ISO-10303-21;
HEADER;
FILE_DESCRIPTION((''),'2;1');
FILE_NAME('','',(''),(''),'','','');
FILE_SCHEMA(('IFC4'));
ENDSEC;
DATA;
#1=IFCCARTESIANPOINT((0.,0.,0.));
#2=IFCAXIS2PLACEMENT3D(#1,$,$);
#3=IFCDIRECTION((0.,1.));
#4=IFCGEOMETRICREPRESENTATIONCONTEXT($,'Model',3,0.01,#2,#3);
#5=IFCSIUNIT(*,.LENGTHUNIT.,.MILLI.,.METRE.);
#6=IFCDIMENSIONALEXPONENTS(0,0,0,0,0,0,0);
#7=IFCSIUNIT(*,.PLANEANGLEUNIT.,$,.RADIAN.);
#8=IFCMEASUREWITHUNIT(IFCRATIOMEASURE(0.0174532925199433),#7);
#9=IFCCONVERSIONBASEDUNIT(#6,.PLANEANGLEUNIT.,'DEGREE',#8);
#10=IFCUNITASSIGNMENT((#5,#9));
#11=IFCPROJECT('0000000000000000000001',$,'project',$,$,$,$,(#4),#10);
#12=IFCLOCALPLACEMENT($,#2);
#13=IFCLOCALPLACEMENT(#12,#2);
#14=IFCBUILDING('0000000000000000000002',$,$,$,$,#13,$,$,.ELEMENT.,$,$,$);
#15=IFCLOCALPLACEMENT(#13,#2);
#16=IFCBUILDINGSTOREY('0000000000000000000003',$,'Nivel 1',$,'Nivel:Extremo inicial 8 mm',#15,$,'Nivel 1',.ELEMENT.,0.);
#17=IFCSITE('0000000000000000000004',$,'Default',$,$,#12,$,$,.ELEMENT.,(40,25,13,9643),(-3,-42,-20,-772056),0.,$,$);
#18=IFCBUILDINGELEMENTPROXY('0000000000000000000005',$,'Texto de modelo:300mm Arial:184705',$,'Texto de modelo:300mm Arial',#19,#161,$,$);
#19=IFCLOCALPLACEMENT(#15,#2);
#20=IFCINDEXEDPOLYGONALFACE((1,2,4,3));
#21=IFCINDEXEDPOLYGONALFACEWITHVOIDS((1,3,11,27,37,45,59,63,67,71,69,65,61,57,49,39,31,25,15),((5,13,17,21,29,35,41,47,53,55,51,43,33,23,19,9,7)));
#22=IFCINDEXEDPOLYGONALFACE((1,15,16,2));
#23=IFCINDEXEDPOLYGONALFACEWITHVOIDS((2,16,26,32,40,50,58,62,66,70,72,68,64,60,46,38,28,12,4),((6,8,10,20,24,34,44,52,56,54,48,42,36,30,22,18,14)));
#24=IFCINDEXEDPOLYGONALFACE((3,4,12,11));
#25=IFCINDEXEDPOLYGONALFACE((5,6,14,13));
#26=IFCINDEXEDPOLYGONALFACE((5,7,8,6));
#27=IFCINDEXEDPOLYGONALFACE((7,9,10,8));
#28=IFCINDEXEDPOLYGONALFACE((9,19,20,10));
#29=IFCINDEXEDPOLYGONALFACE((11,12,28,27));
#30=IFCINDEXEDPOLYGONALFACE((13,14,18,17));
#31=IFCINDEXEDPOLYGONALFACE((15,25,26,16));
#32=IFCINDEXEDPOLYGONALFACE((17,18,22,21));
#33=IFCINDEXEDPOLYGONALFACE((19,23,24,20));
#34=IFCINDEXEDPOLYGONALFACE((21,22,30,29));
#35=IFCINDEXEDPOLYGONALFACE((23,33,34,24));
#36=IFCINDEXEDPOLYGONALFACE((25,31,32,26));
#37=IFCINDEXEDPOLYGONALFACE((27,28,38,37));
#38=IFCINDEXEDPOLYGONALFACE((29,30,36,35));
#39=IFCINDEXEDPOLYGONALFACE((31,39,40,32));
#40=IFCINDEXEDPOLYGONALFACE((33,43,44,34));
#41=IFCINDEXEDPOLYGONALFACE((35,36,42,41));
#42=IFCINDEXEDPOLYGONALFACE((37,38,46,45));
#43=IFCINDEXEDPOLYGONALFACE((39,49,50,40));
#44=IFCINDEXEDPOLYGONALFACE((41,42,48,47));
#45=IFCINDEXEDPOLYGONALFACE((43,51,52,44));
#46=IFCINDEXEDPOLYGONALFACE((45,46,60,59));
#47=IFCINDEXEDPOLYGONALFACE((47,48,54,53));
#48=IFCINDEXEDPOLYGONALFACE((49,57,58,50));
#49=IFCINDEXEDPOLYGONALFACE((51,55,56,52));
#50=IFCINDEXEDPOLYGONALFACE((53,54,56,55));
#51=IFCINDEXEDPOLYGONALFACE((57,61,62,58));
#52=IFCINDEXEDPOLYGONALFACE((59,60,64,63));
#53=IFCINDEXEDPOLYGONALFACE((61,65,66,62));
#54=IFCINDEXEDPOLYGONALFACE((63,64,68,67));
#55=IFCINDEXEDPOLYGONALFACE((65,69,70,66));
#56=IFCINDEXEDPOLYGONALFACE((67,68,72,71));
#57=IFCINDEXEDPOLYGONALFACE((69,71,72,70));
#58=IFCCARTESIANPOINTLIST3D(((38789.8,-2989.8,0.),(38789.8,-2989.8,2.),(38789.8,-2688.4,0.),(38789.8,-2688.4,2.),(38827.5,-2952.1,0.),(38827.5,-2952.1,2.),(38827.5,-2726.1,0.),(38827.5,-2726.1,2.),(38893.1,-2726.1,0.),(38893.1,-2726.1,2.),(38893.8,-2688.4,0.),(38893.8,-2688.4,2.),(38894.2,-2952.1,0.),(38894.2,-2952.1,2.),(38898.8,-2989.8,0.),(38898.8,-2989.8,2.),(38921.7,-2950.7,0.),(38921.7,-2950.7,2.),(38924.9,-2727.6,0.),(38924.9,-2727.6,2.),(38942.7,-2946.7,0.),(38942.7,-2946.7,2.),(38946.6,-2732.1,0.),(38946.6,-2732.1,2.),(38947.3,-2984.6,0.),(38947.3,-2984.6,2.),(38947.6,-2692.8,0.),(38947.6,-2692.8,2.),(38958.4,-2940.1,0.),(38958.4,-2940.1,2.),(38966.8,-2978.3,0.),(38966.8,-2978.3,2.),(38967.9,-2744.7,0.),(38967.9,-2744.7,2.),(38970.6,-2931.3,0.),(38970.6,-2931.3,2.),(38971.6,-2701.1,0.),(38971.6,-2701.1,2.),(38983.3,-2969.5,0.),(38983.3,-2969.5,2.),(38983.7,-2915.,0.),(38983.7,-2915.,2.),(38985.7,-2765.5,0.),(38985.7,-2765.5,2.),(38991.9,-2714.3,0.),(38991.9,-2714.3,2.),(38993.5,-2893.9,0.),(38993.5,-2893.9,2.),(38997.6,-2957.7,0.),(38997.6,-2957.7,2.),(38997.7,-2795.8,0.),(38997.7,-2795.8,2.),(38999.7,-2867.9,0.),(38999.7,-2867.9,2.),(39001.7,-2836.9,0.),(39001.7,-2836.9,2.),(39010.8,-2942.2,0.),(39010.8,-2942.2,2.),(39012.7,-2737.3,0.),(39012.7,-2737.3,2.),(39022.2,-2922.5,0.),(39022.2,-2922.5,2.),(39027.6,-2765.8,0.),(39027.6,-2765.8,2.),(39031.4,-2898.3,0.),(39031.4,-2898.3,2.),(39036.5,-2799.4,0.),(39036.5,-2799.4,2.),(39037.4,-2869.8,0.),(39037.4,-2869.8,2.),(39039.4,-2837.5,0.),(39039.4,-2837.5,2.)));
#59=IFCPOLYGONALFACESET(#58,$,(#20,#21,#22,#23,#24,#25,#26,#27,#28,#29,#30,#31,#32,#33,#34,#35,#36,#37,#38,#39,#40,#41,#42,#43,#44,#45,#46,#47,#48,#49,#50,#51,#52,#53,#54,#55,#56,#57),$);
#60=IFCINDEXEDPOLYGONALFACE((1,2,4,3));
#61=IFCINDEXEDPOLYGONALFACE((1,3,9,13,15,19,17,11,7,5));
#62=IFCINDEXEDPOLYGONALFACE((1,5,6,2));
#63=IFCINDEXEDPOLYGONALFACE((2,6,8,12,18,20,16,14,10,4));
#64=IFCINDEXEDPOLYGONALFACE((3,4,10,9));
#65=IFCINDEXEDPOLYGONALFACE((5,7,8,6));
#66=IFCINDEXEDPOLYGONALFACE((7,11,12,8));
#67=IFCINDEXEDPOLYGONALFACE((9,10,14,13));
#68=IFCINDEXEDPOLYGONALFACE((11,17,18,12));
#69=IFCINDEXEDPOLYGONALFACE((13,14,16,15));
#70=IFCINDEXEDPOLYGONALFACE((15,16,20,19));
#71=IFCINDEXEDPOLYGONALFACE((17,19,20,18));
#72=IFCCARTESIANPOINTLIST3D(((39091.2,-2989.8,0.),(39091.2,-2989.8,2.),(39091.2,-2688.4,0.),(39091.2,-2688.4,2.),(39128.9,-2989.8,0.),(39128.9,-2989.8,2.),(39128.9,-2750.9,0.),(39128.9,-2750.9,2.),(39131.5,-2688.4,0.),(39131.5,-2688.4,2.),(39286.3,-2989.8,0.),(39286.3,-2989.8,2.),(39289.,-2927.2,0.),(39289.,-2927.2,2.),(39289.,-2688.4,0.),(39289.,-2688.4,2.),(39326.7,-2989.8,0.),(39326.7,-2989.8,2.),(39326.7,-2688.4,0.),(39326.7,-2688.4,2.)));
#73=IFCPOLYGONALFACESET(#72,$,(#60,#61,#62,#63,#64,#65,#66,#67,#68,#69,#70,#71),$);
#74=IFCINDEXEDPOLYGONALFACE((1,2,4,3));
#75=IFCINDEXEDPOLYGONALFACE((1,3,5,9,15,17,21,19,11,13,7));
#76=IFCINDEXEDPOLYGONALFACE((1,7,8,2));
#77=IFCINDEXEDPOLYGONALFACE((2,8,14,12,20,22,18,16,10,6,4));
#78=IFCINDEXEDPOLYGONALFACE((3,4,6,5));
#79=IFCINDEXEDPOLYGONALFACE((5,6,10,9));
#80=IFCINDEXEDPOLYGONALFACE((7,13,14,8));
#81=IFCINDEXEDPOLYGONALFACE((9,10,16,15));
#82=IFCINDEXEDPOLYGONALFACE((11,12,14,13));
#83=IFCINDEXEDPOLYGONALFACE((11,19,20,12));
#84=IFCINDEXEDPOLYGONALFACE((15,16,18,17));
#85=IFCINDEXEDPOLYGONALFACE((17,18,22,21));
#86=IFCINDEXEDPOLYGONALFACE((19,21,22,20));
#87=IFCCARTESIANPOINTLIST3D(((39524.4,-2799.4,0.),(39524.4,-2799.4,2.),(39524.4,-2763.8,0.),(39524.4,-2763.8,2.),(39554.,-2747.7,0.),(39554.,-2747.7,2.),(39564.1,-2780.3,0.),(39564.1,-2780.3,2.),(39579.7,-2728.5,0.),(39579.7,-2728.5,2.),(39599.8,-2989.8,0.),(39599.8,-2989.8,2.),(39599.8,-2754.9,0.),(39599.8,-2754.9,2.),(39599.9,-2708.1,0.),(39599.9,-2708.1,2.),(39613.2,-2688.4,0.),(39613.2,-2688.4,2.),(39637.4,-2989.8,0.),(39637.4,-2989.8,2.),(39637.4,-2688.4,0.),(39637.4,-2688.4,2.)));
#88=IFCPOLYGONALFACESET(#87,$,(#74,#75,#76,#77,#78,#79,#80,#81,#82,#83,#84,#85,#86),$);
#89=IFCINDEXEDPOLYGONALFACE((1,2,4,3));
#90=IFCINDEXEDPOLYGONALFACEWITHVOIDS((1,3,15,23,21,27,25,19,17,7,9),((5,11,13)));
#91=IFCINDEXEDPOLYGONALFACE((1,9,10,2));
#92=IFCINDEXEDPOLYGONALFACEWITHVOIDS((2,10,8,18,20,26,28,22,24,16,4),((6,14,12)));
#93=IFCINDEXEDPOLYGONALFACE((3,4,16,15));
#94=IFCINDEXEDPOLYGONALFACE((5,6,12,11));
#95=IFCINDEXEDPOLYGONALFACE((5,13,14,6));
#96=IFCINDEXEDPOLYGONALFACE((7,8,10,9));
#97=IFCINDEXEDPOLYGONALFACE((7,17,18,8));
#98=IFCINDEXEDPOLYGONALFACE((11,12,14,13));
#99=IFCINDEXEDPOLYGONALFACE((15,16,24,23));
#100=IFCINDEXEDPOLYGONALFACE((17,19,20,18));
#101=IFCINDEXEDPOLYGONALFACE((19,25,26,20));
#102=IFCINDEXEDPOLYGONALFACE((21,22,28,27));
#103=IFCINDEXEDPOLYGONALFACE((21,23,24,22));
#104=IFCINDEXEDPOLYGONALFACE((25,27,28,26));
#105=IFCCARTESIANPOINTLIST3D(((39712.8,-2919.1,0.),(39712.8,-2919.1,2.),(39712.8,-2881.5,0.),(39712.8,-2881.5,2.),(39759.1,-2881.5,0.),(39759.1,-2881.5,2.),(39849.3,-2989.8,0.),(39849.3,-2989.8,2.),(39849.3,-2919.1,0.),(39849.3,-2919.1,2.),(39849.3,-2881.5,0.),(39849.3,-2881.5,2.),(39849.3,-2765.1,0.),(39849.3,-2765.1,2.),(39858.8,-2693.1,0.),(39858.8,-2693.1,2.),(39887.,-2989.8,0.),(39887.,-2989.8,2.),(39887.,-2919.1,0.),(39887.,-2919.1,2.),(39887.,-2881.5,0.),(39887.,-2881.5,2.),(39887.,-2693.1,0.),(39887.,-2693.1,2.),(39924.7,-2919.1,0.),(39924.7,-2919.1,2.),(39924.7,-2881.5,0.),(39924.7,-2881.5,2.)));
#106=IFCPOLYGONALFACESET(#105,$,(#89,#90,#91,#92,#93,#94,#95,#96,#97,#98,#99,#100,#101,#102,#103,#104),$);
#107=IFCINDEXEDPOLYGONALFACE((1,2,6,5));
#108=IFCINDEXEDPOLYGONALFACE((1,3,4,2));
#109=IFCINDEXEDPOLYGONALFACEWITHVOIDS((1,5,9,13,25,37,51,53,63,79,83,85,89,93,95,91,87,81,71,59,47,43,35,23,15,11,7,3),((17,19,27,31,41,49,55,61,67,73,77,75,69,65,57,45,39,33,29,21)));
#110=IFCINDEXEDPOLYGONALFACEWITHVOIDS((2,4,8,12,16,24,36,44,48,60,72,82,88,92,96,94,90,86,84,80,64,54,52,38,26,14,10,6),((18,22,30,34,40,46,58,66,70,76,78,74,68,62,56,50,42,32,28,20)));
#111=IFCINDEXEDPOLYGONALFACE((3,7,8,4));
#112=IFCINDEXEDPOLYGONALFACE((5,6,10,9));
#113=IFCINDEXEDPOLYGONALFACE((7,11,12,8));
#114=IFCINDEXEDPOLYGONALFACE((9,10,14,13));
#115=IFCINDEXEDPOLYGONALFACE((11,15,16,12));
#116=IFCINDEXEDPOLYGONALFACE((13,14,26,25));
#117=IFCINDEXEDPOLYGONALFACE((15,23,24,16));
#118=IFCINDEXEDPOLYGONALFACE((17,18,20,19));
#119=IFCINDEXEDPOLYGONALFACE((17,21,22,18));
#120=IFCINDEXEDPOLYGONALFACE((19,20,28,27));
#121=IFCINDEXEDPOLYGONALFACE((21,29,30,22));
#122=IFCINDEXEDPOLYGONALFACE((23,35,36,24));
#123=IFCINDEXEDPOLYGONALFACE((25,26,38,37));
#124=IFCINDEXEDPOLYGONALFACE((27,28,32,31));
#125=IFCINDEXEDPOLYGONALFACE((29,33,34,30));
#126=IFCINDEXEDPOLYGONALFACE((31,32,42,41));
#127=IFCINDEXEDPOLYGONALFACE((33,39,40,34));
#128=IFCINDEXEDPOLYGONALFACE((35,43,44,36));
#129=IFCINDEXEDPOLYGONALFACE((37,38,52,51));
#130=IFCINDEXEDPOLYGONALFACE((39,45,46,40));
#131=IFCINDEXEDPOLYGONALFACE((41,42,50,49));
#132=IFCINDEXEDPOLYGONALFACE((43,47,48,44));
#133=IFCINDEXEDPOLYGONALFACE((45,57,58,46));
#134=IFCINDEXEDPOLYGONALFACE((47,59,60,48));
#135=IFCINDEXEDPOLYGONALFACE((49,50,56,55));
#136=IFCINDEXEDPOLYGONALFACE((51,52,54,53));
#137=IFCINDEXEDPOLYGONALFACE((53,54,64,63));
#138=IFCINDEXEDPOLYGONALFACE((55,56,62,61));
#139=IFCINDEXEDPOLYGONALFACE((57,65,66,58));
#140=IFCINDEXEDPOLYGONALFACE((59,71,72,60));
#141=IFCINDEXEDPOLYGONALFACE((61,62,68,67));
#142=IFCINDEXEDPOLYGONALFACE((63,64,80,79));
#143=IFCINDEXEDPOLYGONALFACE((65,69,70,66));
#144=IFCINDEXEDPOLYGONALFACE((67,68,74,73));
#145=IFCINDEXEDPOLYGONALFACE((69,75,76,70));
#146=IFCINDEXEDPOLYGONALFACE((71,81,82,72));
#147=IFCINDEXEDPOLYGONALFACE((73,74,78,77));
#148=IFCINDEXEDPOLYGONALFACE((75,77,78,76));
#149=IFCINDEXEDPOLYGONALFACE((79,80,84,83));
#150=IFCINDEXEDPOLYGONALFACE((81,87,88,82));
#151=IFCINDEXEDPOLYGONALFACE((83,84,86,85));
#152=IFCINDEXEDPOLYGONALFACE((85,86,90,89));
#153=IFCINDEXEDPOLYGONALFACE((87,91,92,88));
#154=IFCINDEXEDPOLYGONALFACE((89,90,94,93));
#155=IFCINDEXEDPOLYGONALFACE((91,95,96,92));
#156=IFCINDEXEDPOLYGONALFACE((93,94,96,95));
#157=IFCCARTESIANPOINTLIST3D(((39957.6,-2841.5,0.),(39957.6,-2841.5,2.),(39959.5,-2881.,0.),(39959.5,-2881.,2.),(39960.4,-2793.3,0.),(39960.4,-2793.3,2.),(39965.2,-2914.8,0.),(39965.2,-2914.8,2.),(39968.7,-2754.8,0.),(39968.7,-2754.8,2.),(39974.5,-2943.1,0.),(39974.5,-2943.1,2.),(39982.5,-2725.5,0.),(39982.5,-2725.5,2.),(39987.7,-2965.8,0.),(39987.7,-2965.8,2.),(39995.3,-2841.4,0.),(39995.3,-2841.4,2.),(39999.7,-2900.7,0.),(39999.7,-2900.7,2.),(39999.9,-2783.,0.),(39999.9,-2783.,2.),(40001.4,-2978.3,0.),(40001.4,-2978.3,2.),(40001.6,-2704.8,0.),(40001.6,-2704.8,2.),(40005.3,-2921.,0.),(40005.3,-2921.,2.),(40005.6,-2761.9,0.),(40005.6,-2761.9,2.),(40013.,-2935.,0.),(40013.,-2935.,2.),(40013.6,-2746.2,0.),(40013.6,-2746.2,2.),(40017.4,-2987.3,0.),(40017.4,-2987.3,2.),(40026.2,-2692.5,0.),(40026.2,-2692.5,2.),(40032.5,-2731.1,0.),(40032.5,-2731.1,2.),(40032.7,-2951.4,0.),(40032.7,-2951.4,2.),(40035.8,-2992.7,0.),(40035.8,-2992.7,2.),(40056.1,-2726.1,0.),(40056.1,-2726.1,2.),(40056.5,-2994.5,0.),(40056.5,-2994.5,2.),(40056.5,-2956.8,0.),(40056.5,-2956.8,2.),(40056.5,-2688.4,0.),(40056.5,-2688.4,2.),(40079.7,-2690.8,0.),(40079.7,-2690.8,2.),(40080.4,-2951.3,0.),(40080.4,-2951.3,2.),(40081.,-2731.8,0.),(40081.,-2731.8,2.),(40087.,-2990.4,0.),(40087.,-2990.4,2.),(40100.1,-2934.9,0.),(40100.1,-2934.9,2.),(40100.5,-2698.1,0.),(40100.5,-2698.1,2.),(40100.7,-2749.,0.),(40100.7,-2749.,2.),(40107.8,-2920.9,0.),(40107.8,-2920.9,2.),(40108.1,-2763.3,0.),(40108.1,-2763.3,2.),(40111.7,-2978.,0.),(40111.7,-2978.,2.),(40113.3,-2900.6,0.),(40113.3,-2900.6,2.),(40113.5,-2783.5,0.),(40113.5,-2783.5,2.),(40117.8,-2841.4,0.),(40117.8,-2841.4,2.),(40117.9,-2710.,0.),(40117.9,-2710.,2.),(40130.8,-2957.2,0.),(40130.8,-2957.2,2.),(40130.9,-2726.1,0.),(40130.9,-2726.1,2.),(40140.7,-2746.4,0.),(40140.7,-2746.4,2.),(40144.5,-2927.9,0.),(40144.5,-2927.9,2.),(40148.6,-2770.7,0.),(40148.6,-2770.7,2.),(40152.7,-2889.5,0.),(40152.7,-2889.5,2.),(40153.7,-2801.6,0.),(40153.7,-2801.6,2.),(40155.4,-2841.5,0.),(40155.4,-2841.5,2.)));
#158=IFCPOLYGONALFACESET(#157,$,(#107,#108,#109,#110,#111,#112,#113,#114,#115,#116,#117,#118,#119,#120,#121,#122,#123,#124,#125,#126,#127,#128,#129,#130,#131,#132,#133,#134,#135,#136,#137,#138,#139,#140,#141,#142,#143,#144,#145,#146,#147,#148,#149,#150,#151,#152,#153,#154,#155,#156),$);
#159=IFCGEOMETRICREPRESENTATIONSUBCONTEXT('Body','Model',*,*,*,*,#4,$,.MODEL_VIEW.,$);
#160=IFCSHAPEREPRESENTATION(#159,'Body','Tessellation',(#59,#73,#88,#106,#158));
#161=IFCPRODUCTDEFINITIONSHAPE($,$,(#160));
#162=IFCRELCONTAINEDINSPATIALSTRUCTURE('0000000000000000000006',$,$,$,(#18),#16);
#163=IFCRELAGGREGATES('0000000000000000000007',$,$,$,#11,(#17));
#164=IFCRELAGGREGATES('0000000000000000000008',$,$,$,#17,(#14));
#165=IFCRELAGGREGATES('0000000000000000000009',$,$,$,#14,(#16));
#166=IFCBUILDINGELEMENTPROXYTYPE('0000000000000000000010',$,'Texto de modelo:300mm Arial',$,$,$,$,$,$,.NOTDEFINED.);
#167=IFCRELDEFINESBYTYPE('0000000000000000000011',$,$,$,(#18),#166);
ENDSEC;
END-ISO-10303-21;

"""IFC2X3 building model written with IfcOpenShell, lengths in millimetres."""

from ifc_helpers import new_model, entity, si_unit, converted_unit, direction, frame, origin, place, context, subcontext, project, spatial, polyline, outline, extrude, type_object, element, save


model = new_model("IFC2X3")

# Units and contexts
model_context = context("Model", 3, precision=0.01, world=origin(), true_north=direction((0.0, 1.0)))
body_context = subcontext(model_context, "Body", "Model", "MODEL_VIEW")
ifc_project = project(units=[si_unit("LENGTHUNIT", "METRE", prefix="MILLI"), converted_unit("PLANEANGLEUNIT", "DEGREE", entity("IfcRatioMeasure", 0.0174532925199433), si_unit("PLANEANGLEUNIT", "RADIAN"), dimensions=[0, 0, 0, 0, 0, 0, 0])], contexts=[model_context])

# Site, building, storey
site_placement = place(None, origin())
site = spatial("IfcSite", under=ifc_project, at=site_placement, Name="Default", CompositionType="ELEMENT", RefLatitude=(40, 25, 13, 9643), RefLongitude=(-3, -42, -20, -772056), RefElevation=0.0)
building_placement = place(site_placement, origin())
building = spatial("IfcBuilding", under=site, at=building_placement, CompositionType="ELEMENT")
storey_placement = place(building_placement, origin())
storey = spatial("IfcBuildingStorey", under=building, at=storey_placement, Name="Nivel 1", ObjectType="Nivel:Extremo inicial 8 mm", LongName="Nivel 1", CompositionType="ELEMENT", Elevation=0.0)

# Building element proxy
building_element_proxy_type_1 = type_object("IfcBuildingElementProxyType", Name="Texto de modelo:300mm Arial", PredefinedType="NOTDEFINED")
proxy_1_placement = place(storey_placement, frame((38789.8, -2994.5, 0.0)))
element("IfcBuildingElementProxy", 1, at=proxy_1_placement, inside=storey, type_object=building_element_proxy_type_1, Name="Texto de modelo:300mm Arial:184705", ObjectType="Texto de modelo:300mm Arial", context=body_context, shape_type="SweptSolid", body=[
    extrude(outline(polyline([(-178.4, -141.0), (-69.4, -141.0), (-21.0, -135.8), (-1.4, -129.5), (15.0, -120.7), (29.4, -108.9), (42.6, -93.4), (54.0, -73.7), (63.2, -49.5), (69.2, -21.0), (71.2, 11.3), (68.2, 49.4), (59.3, 83.0), (44.5, 111.5), (23.7, 134.5), (3.4, 147.7), (-20.6, 156.1), (-74.4, 160.4), (-178.4, 160.4), (-178.4, -141.0)]), holes=[polyline([(-140.7, -103.3), (-140.7, 122.7), (-75.1, 122.7), (-43.3, 121.2), (-21.7, 116.7), (-0.4, 104.1), (17.4, 83.3), (29.5, 53.0), (33.5, 11.9), (31.5, -19.1), (25.3, -45.1), (15.5, -66.2), (2.4, -82.5), (-9.8, -91.3), (-25.6, -97.9), (-46.5, -101.9), (-74.1, -103.3), (-140.7, -103.3)])]), frame((178.4, 145.7, 0.0)), (0.0, 0.0, 1.0), 2.0),
    extrude(outline(polyline([(-117.7, -150.7), (-80.1, -150.7), (-80.1, 88.1), (77.4, -150.7), (117.7, -150.7), (117.7, 150.7), (80.1, 150.7), (80.1, -88.1), (-77.4, 150.7), (-117.7, 150.7), (-117.7, -150.7)])), frame((419.1, 155.4, 0.0)), (0.0, 0.0, 1.0), 2.0),
    extrude(outline(polyline([(-204.4, -52.5), (97.0, -52.5), (97.0, -28.2), (77.2, -14.9), (56.9, 5.3), (37.7, 30.9), (21.6, 60.5), (-14.0, 60.5), (5.0, 20.8), (30.4, -14.9), (-204.4, -14.9), (-204.4, -52.5)])), frame((795.1, 209.1, 0.0), z_axis=(0.0, 0.0, 1.0), x_axis=(0.0, 1.0, 0.0)), (0.0, 0.0, 1.0), 2.0),
    extrude(outline(polyline([(-3.4, -109.2), (34.2, -109.2), (34.2, -38.5), (71.9, -38.5), (71.9, -0.9), (34.2, -0.9), (34.2, 187.5), (6.0, 187.5), (-140.0, -0.9), (-140.0, -38.5), (-3.4, -38.5), (-3.4, -109.2)]), holes=[polyline([(-3.4, -0.9), (-93.6, -0.9), (-3.4, 115.5), (-3.4, -0.9)])]), frame((1062.9, 113.9, 0.0)), (0.0, 0.0, 1.0), 2.0),
    extrude(outline(polyline([(-5.6, -99.5), (33.9, -99.5), (68.0, -95.5), (96.7, -87.5), (120.0, -75.5), (133.2, -62.4), (142.9, -46.8), (149.1, -28.7), (151.9, -8.0), (149.2, 22.6), (138.0, 47.8), (118.2, 67.9), (89.5, 82.9), (51.6, 93.0), (3.8, 98.0), (-36.2, 98.2), (-67.3, 94.5), (-91.9, 87.9), (-112.6, 79.0), (-129.4, 66.8), (-142.0, 50.0), (-150.3, 29.6), (-153.8, 6.5), (-151.2, -23.9), (-140.1, -49.1), (-120.3, -69.2), (-91.7, -84.4), (-53.6, -94.5), (-5.6, -99.5)]), holes=[polyline([(-3.9, -61.9), (-62.1, -54.6), (-82.9, -47.9), (-98.1, -39.2), (-112.3, -19.5), (-116.2, 4.3), (-109.3, 28.9), (-91.2, 47.7), (-76.5, 54.5), (-56.1, 58.9), (1.9, 60.4), (60.8, 53.2), (80.8, 46.7), (94.5, 38.3), (109.9, 17.8), (114.3, -6.3), (107.7, -29.8), (90.4, -48.7), (76.0, -55.8), (55.5, -60.3), (-3.9, -61.9)])]), frame((1267.5, 152.1, 0.0), z_axis=(0.0, 0.0, 1.0), x_axis=(0.047515, -0.998871, 0.0)), (0.0, 0.0, 1.0), 2.0),
])

save(model, "model.ifc")
